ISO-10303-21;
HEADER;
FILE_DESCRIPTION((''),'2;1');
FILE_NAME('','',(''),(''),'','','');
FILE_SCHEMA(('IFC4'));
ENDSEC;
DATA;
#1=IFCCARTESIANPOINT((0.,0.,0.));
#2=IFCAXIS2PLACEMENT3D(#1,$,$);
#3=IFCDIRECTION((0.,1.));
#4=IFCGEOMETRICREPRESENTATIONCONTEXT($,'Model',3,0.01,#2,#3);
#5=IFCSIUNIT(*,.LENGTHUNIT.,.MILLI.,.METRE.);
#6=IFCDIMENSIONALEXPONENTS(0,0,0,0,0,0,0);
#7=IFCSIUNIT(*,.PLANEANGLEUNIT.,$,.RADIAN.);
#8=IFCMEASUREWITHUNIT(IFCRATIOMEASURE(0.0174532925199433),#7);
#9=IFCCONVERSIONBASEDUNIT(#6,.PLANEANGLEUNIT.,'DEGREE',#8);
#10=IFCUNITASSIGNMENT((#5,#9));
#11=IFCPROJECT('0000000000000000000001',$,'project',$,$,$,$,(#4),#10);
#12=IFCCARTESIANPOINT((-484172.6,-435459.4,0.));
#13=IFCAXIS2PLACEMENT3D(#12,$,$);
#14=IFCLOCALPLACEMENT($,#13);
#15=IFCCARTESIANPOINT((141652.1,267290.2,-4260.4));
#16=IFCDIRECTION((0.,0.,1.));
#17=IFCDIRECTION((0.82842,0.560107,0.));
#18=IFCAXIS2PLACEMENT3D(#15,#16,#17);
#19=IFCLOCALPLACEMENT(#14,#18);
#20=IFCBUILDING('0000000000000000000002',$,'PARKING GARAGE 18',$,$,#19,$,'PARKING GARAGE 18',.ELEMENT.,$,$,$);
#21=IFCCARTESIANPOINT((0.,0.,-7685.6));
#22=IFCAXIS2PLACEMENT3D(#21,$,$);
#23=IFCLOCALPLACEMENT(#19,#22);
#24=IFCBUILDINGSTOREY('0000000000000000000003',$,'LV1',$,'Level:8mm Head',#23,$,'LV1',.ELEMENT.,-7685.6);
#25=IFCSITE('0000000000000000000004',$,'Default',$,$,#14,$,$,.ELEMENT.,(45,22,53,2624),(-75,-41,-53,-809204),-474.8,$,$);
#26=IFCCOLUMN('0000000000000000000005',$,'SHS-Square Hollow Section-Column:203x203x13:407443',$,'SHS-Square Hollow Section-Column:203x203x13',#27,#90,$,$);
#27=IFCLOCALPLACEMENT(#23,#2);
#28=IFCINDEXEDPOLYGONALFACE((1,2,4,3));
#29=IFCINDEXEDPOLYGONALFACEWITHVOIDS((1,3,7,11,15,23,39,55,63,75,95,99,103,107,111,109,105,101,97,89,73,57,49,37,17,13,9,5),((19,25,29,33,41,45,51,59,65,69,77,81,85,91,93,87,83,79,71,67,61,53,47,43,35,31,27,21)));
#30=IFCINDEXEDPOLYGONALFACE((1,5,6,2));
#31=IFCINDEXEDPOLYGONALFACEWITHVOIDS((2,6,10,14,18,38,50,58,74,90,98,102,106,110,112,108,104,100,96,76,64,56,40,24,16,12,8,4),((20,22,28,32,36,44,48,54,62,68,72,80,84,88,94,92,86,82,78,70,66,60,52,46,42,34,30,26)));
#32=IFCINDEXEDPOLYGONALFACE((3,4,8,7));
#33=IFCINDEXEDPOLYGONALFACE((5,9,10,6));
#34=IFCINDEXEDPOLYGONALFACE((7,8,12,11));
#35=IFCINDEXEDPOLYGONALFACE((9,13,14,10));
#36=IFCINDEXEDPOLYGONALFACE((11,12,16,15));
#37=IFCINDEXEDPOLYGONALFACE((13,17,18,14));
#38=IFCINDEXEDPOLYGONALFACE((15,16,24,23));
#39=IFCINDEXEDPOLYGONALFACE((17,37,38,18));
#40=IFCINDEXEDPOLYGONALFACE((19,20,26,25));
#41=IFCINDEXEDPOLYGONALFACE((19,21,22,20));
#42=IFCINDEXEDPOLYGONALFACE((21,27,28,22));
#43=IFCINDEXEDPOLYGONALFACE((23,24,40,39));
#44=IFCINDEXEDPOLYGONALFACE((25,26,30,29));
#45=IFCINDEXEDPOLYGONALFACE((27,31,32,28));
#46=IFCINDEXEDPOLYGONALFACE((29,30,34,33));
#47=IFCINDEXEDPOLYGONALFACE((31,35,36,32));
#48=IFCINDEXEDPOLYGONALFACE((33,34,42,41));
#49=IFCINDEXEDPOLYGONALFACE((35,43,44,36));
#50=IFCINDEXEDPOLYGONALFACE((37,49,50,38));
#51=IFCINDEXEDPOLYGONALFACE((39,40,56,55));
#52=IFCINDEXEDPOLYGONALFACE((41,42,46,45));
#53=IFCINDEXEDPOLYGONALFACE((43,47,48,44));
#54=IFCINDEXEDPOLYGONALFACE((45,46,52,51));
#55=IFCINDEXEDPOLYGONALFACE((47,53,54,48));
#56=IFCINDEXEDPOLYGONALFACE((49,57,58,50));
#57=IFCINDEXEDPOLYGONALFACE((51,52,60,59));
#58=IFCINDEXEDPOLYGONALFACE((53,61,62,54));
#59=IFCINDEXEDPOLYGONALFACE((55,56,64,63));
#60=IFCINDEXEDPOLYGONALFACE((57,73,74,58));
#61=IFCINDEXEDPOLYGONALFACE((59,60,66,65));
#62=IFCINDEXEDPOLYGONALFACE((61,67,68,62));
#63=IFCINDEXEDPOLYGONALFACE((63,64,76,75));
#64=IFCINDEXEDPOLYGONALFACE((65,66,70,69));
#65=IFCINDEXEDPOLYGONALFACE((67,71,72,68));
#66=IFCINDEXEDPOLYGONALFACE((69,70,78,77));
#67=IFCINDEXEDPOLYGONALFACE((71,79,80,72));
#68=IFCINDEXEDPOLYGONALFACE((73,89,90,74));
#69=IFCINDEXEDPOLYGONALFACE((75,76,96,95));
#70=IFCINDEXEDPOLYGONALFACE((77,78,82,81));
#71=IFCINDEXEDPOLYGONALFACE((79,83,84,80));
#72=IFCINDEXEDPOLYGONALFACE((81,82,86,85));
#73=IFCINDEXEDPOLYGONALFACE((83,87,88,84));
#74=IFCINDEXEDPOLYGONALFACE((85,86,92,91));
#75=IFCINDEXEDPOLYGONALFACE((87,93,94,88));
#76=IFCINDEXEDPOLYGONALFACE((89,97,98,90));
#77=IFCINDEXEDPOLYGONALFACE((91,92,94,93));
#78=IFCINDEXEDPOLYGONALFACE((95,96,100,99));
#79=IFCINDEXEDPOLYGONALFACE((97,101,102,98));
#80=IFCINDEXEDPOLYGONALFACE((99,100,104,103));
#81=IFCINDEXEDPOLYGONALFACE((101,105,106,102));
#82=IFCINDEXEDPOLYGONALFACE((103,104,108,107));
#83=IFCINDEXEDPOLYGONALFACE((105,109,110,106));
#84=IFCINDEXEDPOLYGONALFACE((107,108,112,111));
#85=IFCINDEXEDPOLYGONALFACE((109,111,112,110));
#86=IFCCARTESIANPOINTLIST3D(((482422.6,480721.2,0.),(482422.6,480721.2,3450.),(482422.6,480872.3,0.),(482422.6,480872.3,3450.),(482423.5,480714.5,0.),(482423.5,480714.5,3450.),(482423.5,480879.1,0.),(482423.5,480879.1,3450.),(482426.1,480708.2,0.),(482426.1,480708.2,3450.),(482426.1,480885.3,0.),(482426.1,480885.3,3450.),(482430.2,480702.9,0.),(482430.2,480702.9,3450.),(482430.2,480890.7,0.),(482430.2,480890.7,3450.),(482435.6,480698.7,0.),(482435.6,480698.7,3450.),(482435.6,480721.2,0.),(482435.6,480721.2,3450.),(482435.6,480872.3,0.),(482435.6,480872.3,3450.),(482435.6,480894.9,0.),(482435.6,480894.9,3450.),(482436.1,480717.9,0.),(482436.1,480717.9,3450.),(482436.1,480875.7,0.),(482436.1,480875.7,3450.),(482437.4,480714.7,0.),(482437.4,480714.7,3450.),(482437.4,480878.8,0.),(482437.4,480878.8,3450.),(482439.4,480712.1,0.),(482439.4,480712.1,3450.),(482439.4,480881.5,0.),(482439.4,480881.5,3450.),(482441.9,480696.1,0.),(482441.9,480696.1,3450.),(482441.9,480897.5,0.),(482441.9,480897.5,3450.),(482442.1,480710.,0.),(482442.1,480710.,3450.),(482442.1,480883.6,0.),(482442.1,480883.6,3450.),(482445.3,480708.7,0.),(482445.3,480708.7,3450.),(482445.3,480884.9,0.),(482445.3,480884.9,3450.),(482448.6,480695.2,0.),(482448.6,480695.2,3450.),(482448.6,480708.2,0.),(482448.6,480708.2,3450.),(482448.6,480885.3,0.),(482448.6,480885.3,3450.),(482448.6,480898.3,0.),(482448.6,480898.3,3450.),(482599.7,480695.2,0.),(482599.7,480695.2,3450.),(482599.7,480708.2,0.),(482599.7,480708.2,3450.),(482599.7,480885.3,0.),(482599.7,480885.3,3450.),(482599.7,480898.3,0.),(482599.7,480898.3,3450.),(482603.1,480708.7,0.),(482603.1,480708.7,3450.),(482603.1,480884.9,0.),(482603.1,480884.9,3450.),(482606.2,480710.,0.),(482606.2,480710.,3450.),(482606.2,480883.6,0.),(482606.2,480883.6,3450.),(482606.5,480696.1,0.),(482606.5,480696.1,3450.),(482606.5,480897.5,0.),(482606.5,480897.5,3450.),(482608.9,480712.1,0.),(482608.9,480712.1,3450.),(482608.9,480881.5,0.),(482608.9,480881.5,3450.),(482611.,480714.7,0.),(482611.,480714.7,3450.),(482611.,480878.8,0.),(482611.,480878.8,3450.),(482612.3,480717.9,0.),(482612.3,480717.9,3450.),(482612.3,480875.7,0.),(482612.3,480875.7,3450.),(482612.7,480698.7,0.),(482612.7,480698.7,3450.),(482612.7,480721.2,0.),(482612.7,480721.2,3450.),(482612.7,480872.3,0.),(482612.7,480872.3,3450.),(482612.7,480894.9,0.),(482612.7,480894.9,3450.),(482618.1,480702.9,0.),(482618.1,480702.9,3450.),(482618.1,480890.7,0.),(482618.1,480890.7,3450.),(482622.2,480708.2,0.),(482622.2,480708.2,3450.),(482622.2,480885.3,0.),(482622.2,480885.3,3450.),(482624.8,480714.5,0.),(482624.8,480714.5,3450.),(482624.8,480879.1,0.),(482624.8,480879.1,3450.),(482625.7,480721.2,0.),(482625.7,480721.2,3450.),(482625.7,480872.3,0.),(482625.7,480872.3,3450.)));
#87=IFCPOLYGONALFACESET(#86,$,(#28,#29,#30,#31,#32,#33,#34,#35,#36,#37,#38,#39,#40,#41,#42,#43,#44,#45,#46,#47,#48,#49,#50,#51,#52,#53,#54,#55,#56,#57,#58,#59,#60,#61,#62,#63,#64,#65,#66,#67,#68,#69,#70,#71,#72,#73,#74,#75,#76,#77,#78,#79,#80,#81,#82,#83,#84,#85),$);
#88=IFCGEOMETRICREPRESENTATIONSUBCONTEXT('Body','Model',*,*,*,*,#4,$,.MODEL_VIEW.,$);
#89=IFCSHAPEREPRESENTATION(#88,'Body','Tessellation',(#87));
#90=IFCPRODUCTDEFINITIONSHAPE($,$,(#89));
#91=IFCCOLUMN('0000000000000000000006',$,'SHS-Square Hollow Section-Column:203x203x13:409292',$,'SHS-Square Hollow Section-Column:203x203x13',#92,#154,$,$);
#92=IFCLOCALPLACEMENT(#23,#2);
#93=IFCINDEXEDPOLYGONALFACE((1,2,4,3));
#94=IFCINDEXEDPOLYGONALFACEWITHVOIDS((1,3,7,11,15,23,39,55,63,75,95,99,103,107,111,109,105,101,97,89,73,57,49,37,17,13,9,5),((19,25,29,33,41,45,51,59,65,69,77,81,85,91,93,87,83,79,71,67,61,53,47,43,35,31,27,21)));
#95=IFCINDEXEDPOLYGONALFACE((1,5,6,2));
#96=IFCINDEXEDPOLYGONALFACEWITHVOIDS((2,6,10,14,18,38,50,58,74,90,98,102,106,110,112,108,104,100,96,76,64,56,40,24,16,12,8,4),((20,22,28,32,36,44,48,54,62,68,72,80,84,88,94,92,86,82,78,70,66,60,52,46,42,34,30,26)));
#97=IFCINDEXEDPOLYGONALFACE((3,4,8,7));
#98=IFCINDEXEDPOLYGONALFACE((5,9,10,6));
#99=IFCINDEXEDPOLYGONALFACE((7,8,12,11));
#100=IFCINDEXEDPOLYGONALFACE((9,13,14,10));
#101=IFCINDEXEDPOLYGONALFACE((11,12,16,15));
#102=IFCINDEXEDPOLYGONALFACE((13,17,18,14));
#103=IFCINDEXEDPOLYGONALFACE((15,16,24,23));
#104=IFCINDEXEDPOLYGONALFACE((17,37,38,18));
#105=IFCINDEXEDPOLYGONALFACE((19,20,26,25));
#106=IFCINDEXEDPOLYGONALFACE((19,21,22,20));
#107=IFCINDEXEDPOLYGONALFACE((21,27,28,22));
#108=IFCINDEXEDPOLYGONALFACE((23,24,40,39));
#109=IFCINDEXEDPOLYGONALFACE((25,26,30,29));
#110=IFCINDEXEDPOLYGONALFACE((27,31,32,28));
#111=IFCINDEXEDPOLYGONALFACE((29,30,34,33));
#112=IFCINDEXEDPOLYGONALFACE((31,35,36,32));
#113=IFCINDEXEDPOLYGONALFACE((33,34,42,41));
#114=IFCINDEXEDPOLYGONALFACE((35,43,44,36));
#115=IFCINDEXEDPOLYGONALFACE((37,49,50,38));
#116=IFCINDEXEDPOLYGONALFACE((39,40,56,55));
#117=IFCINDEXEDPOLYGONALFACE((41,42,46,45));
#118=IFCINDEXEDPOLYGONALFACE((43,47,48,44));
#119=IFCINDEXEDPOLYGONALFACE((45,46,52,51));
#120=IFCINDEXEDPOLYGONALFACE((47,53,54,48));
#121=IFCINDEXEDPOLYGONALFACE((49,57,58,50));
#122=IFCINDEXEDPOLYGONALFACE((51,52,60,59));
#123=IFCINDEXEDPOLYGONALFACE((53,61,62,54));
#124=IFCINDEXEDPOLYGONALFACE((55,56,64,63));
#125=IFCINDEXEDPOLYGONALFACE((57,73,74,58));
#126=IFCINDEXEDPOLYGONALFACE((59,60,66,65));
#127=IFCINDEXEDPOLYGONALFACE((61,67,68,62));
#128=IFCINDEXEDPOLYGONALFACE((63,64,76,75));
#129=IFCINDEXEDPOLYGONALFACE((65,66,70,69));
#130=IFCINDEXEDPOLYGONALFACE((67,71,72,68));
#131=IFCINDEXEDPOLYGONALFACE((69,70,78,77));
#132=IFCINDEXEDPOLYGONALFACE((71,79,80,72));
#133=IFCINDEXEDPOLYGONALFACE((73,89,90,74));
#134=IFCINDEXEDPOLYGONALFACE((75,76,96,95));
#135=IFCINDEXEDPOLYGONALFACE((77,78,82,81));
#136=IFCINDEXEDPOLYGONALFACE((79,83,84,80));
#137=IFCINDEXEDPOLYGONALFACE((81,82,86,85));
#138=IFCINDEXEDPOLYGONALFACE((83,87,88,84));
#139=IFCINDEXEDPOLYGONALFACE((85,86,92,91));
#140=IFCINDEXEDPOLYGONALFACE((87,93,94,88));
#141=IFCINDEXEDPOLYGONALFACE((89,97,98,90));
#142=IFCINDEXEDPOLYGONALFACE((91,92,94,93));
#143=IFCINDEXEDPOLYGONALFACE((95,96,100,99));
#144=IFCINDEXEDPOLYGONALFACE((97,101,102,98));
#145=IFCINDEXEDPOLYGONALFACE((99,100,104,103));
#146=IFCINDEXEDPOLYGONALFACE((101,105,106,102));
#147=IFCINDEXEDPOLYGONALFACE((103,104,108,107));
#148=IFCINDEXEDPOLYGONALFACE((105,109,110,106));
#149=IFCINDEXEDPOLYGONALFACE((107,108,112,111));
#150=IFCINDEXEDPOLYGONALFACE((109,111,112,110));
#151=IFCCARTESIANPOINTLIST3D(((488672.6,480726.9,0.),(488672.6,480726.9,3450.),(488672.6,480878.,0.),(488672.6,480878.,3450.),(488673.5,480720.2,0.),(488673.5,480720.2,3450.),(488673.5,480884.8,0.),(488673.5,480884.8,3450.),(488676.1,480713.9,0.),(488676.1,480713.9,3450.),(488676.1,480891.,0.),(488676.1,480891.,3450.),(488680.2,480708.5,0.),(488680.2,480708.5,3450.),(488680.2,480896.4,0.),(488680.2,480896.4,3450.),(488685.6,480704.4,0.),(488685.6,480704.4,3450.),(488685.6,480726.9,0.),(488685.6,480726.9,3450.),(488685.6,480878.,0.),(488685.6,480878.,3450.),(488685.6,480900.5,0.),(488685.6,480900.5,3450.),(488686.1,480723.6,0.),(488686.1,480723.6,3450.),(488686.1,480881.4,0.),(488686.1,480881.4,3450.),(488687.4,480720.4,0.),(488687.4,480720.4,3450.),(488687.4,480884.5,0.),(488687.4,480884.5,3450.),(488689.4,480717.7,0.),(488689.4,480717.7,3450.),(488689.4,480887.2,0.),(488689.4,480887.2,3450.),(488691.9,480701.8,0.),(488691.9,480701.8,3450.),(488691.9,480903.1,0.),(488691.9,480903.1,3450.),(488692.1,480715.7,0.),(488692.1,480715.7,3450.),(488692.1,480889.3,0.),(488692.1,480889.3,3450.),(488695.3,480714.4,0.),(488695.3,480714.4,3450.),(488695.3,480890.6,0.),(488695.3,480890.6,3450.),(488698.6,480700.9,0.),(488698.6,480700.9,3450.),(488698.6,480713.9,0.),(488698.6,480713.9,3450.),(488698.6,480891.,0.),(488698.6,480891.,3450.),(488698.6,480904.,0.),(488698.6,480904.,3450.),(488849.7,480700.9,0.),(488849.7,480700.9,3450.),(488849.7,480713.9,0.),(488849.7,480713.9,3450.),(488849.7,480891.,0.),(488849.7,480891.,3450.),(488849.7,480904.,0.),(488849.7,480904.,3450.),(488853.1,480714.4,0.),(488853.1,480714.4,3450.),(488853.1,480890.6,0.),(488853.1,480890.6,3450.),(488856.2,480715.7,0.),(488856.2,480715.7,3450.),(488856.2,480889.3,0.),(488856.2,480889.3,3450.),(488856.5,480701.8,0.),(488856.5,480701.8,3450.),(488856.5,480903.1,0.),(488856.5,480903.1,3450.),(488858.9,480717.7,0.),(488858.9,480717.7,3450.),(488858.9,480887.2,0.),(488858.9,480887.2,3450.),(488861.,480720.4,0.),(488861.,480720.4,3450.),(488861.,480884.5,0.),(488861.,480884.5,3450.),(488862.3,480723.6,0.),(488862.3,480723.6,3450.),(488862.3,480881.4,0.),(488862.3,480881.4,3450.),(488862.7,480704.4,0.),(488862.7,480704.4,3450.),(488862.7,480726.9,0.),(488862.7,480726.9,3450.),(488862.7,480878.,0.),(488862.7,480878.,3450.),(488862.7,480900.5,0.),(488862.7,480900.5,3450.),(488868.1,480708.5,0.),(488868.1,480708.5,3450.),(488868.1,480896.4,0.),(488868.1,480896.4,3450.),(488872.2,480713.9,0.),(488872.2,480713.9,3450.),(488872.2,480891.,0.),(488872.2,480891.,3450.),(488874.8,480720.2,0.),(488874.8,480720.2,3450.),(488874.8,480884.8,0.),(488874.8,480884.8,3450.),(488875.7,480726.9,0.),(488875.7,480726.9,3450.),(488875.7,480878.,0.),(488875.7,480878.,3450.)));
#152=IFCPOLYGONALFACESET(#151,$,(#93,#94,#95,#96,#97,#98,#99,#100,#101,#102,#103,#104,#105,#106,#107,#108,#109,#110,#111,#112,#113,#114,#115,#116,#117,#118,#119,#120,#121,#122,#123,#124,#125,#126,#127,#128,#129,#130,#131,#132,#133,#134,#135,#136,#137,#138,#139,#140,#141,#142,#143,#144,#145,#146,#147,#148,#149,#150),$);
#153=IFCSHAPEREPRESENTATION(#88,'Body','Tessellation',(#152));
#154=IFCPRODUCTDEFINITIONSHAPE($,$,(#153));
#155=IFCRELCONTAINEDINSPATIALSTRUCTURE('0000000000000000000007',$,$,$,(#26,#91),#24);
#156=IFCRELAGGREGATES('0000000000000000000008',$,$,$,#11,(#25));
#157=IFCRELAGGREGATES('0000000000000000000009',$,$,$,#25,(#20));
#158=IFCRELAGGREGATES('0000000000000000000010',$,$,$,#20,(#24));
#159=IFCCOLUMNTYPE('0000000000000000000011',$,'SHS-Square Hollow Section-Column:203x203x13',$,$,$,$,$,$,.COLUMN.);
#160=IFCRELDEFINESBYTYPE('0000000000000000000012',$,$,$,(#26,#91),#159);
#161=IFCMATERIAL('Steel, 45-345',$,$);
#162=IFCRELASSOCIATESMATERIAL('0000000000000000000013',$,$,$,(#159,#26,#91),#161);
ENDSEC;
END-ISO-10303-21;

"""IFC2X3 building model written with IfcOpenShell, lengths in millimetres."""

from ifc_helpers import new_model, entity, si_unit, converted_unit, direction, frame, frame_2d, origin, place, context, subcontext, project, spatial, polyline, circle_curve, parameter, trimmed, segment, composite_curve, outline, extrude, source, transform, mapped, material, type_object, type_shapes, element, save


model = new_model("IFC2X3")

# Units and contexts
model_context = context("Model", 3, precision=0.01, world=origin(), true_north=direction((0.0, 1.0)))
body_context = subcontext(model_context, "Body", "Model", "MODEL_VIEW")
ifc_project = project(units=[si_unit("LENGTHUNIT", "METRE", prefix="MILLI"), converted_unit("PLANEANGLEUNIT", "DEGREE", entity("IfcRatioMeasure", 0.0174532925199433), si_unit("PLANEANGLEUNIT", "RADIAN"), dimensions=[0, 0, 0, 0, 0, 0, 0])], contexts=[model_context])

# Site, building, storey
site_placement = place(None, frame((-484172.6, -435459.4, 0.0)))
site = spatial("IfcSite", under=ifc_project, at=site_placement, Name="Default", CompositionType="ELEMENT", RefLatitude=(45, 22, 53, 2624), RefLongitude=(-75, -41, -53, -809204), RefElevation=-474.8)
building_placement = place(site_placement, frame((141652.1, 267290.2, -4260.4), z_axis=(0.0, 0.0, 1.0), x_axis=(0.82842, 0.560107, 0.0)))
building = spatial("IfcBuilding", under=site, at=building_placement, Name="PARKING GARAGE 18", LongName="PARKING GARAGE 18", CompositionType="ELEMENT")
storey_placement = place(building_placement, frame((0.0, 0.0, -7685.6)))
storey = spatial("IfcBuildingStorey", under=building, at=storey_placement, Name="LV1", ObjectType="Level:8mm Head", LongName="LV1", CompositionType="ELEMENT", Elevation=-7685.6)

# Columns
ifc_material_1 = material(Name="Steel, 45-345")
column_type = type_object("IfcColumnType", Name="SHS-Square Hollow Section-Column:203x203x13", PredefinedType="COLUMN", material=ifc_material_1)
shared_shape_1 = source(origin(), body_context, "Body", "SweptSolid", [
    extrude(outline(composite_curve([segment(polyline([(-75.6, -101.5), (75.6, -101.5)]), True, "CONTINUOUS"), segment(trimmed(circle_curve(frame_2d((75.6, -75.6), x_axis=(-1.0, 0.0)), 26.0), [parameter(90.0)], [parameter(180.0)], True, "PARAMETER"), True, "CONTINUOUS"), segment(polyline([(101.5, -75.6), (101.5, 75.6)]), True, "CONTINUOUS"), segment(trimmed(circle_curve(frame_2d((75.5, 75.6), x_axis=(-1.0, 0.0)), 26.0), [parameter(180.0)], [parameter(270.0)], True, "PARAMETER"), True, "CONTINUOUS"), segment(polyline([(75.5, 101.6), (-75.5, 101.6)]), True, "CONTINUOUS"), segment(trimmed(circle_curve(frame_2d((-75.5, 75.5), x_axis=(-1.0, 0.0)), 26.0), [parameter(270.0)], [parameter(360.0)], True, "PARAMETER"), True, "CONTINUOUS"), segment(polyline([(-101.5, 75.5), (-101.5, -75.6)]), True, "CONTINUOUS"), segment(trimmed(circle_curve(frame_2d((-75.6, -75.6), x_axis=(-1.0, 0.0)), 26.0), [parameter(360.0)], [parameter(90.0)], True, "PARAMETER"), True, "CONTINUOUS")], self_intersect=False), holes=[composite_curve([segment(trimmed(circle_curve(frame_2d((-75.6, -75.6), x_axis=(-1.0, 0.0)), 13.0), [parameter(0.0)], [parameter(90.0)], True, "PARAMETER"), False, "CONTINUOUS"), segment(polyline([(-88.5, -75.6), (-88.5, 75.6)]), True, "CONTINUOUS"), segment(trimmed(circle_curve(frame_2d((-75.6, 75.6), x_axis=(-1.0, 0.0)), 13.0), [parameter(270.0)], [parameter(0.0)], True, "PARAMETER"), False, "CONTINUOUS"), segment(polyline([(-75.6, 88.6), (75.5, 88.6)]), True, "CONTINUOUS"), segment(trimmed(circle_curve(frame_2d((75.5, 75.5), x_axis=(-1.0, 0.0)), 13.0), [parameter(180.0)], [parameter(270.0)], True, "PARAMETER"), False, "CONTINUOUS"), segment(polyline([(88.6, 75.5), (88.6, -75.5)]), True, "CONTINUOUS"), segment(trimmed(circle_curve(frame_2d((75.6, -75.5), x_axis=(-1.0, 0.0)), 13.0), [parameter(90.0)], [parameter(180.0)], True, "PARAMETER"), False, "CONTINUOUS"), segment(polyline([(75.6, -88.5), (-75.6, -88.5)]), True, "CONTINUOUS")], self_intersect=False)]), frame((0.0, 0.0, -7685.6), z_axis=(0.0, 0.0, 1.0), x_axis=(-1.0, 0.0, 0.0)), (0.0, 0.0, 1.0), 3450.0),
])
type_shapes(column_type, [shared_shape_1])
for number, where, name in (
    (1, (482524.2, 480796.8, 7685.6), "SHS-Square Hollow Section-Column:203x203x13:407443"),
    (2, (488774.2, 480802.5, 7685.6), "SHS-Square Hollow Section-Column:203x203x13:409292"),
):
    element("IfcColumn", number, at=place(storey_placement, frame(where)), inside=storey, type_object=column_type, material=ifc_material_1, Name=name, ObjectType="SHS-Square Hollow Section-Column:203x203x13", context=body_context, shape_type="MappedRepresentation", body=[
        mapped(shared_shape_1, transform((0.0, 0.0, 0.0), scale=1.0)),
    ])

save(model, "model.ifc")
